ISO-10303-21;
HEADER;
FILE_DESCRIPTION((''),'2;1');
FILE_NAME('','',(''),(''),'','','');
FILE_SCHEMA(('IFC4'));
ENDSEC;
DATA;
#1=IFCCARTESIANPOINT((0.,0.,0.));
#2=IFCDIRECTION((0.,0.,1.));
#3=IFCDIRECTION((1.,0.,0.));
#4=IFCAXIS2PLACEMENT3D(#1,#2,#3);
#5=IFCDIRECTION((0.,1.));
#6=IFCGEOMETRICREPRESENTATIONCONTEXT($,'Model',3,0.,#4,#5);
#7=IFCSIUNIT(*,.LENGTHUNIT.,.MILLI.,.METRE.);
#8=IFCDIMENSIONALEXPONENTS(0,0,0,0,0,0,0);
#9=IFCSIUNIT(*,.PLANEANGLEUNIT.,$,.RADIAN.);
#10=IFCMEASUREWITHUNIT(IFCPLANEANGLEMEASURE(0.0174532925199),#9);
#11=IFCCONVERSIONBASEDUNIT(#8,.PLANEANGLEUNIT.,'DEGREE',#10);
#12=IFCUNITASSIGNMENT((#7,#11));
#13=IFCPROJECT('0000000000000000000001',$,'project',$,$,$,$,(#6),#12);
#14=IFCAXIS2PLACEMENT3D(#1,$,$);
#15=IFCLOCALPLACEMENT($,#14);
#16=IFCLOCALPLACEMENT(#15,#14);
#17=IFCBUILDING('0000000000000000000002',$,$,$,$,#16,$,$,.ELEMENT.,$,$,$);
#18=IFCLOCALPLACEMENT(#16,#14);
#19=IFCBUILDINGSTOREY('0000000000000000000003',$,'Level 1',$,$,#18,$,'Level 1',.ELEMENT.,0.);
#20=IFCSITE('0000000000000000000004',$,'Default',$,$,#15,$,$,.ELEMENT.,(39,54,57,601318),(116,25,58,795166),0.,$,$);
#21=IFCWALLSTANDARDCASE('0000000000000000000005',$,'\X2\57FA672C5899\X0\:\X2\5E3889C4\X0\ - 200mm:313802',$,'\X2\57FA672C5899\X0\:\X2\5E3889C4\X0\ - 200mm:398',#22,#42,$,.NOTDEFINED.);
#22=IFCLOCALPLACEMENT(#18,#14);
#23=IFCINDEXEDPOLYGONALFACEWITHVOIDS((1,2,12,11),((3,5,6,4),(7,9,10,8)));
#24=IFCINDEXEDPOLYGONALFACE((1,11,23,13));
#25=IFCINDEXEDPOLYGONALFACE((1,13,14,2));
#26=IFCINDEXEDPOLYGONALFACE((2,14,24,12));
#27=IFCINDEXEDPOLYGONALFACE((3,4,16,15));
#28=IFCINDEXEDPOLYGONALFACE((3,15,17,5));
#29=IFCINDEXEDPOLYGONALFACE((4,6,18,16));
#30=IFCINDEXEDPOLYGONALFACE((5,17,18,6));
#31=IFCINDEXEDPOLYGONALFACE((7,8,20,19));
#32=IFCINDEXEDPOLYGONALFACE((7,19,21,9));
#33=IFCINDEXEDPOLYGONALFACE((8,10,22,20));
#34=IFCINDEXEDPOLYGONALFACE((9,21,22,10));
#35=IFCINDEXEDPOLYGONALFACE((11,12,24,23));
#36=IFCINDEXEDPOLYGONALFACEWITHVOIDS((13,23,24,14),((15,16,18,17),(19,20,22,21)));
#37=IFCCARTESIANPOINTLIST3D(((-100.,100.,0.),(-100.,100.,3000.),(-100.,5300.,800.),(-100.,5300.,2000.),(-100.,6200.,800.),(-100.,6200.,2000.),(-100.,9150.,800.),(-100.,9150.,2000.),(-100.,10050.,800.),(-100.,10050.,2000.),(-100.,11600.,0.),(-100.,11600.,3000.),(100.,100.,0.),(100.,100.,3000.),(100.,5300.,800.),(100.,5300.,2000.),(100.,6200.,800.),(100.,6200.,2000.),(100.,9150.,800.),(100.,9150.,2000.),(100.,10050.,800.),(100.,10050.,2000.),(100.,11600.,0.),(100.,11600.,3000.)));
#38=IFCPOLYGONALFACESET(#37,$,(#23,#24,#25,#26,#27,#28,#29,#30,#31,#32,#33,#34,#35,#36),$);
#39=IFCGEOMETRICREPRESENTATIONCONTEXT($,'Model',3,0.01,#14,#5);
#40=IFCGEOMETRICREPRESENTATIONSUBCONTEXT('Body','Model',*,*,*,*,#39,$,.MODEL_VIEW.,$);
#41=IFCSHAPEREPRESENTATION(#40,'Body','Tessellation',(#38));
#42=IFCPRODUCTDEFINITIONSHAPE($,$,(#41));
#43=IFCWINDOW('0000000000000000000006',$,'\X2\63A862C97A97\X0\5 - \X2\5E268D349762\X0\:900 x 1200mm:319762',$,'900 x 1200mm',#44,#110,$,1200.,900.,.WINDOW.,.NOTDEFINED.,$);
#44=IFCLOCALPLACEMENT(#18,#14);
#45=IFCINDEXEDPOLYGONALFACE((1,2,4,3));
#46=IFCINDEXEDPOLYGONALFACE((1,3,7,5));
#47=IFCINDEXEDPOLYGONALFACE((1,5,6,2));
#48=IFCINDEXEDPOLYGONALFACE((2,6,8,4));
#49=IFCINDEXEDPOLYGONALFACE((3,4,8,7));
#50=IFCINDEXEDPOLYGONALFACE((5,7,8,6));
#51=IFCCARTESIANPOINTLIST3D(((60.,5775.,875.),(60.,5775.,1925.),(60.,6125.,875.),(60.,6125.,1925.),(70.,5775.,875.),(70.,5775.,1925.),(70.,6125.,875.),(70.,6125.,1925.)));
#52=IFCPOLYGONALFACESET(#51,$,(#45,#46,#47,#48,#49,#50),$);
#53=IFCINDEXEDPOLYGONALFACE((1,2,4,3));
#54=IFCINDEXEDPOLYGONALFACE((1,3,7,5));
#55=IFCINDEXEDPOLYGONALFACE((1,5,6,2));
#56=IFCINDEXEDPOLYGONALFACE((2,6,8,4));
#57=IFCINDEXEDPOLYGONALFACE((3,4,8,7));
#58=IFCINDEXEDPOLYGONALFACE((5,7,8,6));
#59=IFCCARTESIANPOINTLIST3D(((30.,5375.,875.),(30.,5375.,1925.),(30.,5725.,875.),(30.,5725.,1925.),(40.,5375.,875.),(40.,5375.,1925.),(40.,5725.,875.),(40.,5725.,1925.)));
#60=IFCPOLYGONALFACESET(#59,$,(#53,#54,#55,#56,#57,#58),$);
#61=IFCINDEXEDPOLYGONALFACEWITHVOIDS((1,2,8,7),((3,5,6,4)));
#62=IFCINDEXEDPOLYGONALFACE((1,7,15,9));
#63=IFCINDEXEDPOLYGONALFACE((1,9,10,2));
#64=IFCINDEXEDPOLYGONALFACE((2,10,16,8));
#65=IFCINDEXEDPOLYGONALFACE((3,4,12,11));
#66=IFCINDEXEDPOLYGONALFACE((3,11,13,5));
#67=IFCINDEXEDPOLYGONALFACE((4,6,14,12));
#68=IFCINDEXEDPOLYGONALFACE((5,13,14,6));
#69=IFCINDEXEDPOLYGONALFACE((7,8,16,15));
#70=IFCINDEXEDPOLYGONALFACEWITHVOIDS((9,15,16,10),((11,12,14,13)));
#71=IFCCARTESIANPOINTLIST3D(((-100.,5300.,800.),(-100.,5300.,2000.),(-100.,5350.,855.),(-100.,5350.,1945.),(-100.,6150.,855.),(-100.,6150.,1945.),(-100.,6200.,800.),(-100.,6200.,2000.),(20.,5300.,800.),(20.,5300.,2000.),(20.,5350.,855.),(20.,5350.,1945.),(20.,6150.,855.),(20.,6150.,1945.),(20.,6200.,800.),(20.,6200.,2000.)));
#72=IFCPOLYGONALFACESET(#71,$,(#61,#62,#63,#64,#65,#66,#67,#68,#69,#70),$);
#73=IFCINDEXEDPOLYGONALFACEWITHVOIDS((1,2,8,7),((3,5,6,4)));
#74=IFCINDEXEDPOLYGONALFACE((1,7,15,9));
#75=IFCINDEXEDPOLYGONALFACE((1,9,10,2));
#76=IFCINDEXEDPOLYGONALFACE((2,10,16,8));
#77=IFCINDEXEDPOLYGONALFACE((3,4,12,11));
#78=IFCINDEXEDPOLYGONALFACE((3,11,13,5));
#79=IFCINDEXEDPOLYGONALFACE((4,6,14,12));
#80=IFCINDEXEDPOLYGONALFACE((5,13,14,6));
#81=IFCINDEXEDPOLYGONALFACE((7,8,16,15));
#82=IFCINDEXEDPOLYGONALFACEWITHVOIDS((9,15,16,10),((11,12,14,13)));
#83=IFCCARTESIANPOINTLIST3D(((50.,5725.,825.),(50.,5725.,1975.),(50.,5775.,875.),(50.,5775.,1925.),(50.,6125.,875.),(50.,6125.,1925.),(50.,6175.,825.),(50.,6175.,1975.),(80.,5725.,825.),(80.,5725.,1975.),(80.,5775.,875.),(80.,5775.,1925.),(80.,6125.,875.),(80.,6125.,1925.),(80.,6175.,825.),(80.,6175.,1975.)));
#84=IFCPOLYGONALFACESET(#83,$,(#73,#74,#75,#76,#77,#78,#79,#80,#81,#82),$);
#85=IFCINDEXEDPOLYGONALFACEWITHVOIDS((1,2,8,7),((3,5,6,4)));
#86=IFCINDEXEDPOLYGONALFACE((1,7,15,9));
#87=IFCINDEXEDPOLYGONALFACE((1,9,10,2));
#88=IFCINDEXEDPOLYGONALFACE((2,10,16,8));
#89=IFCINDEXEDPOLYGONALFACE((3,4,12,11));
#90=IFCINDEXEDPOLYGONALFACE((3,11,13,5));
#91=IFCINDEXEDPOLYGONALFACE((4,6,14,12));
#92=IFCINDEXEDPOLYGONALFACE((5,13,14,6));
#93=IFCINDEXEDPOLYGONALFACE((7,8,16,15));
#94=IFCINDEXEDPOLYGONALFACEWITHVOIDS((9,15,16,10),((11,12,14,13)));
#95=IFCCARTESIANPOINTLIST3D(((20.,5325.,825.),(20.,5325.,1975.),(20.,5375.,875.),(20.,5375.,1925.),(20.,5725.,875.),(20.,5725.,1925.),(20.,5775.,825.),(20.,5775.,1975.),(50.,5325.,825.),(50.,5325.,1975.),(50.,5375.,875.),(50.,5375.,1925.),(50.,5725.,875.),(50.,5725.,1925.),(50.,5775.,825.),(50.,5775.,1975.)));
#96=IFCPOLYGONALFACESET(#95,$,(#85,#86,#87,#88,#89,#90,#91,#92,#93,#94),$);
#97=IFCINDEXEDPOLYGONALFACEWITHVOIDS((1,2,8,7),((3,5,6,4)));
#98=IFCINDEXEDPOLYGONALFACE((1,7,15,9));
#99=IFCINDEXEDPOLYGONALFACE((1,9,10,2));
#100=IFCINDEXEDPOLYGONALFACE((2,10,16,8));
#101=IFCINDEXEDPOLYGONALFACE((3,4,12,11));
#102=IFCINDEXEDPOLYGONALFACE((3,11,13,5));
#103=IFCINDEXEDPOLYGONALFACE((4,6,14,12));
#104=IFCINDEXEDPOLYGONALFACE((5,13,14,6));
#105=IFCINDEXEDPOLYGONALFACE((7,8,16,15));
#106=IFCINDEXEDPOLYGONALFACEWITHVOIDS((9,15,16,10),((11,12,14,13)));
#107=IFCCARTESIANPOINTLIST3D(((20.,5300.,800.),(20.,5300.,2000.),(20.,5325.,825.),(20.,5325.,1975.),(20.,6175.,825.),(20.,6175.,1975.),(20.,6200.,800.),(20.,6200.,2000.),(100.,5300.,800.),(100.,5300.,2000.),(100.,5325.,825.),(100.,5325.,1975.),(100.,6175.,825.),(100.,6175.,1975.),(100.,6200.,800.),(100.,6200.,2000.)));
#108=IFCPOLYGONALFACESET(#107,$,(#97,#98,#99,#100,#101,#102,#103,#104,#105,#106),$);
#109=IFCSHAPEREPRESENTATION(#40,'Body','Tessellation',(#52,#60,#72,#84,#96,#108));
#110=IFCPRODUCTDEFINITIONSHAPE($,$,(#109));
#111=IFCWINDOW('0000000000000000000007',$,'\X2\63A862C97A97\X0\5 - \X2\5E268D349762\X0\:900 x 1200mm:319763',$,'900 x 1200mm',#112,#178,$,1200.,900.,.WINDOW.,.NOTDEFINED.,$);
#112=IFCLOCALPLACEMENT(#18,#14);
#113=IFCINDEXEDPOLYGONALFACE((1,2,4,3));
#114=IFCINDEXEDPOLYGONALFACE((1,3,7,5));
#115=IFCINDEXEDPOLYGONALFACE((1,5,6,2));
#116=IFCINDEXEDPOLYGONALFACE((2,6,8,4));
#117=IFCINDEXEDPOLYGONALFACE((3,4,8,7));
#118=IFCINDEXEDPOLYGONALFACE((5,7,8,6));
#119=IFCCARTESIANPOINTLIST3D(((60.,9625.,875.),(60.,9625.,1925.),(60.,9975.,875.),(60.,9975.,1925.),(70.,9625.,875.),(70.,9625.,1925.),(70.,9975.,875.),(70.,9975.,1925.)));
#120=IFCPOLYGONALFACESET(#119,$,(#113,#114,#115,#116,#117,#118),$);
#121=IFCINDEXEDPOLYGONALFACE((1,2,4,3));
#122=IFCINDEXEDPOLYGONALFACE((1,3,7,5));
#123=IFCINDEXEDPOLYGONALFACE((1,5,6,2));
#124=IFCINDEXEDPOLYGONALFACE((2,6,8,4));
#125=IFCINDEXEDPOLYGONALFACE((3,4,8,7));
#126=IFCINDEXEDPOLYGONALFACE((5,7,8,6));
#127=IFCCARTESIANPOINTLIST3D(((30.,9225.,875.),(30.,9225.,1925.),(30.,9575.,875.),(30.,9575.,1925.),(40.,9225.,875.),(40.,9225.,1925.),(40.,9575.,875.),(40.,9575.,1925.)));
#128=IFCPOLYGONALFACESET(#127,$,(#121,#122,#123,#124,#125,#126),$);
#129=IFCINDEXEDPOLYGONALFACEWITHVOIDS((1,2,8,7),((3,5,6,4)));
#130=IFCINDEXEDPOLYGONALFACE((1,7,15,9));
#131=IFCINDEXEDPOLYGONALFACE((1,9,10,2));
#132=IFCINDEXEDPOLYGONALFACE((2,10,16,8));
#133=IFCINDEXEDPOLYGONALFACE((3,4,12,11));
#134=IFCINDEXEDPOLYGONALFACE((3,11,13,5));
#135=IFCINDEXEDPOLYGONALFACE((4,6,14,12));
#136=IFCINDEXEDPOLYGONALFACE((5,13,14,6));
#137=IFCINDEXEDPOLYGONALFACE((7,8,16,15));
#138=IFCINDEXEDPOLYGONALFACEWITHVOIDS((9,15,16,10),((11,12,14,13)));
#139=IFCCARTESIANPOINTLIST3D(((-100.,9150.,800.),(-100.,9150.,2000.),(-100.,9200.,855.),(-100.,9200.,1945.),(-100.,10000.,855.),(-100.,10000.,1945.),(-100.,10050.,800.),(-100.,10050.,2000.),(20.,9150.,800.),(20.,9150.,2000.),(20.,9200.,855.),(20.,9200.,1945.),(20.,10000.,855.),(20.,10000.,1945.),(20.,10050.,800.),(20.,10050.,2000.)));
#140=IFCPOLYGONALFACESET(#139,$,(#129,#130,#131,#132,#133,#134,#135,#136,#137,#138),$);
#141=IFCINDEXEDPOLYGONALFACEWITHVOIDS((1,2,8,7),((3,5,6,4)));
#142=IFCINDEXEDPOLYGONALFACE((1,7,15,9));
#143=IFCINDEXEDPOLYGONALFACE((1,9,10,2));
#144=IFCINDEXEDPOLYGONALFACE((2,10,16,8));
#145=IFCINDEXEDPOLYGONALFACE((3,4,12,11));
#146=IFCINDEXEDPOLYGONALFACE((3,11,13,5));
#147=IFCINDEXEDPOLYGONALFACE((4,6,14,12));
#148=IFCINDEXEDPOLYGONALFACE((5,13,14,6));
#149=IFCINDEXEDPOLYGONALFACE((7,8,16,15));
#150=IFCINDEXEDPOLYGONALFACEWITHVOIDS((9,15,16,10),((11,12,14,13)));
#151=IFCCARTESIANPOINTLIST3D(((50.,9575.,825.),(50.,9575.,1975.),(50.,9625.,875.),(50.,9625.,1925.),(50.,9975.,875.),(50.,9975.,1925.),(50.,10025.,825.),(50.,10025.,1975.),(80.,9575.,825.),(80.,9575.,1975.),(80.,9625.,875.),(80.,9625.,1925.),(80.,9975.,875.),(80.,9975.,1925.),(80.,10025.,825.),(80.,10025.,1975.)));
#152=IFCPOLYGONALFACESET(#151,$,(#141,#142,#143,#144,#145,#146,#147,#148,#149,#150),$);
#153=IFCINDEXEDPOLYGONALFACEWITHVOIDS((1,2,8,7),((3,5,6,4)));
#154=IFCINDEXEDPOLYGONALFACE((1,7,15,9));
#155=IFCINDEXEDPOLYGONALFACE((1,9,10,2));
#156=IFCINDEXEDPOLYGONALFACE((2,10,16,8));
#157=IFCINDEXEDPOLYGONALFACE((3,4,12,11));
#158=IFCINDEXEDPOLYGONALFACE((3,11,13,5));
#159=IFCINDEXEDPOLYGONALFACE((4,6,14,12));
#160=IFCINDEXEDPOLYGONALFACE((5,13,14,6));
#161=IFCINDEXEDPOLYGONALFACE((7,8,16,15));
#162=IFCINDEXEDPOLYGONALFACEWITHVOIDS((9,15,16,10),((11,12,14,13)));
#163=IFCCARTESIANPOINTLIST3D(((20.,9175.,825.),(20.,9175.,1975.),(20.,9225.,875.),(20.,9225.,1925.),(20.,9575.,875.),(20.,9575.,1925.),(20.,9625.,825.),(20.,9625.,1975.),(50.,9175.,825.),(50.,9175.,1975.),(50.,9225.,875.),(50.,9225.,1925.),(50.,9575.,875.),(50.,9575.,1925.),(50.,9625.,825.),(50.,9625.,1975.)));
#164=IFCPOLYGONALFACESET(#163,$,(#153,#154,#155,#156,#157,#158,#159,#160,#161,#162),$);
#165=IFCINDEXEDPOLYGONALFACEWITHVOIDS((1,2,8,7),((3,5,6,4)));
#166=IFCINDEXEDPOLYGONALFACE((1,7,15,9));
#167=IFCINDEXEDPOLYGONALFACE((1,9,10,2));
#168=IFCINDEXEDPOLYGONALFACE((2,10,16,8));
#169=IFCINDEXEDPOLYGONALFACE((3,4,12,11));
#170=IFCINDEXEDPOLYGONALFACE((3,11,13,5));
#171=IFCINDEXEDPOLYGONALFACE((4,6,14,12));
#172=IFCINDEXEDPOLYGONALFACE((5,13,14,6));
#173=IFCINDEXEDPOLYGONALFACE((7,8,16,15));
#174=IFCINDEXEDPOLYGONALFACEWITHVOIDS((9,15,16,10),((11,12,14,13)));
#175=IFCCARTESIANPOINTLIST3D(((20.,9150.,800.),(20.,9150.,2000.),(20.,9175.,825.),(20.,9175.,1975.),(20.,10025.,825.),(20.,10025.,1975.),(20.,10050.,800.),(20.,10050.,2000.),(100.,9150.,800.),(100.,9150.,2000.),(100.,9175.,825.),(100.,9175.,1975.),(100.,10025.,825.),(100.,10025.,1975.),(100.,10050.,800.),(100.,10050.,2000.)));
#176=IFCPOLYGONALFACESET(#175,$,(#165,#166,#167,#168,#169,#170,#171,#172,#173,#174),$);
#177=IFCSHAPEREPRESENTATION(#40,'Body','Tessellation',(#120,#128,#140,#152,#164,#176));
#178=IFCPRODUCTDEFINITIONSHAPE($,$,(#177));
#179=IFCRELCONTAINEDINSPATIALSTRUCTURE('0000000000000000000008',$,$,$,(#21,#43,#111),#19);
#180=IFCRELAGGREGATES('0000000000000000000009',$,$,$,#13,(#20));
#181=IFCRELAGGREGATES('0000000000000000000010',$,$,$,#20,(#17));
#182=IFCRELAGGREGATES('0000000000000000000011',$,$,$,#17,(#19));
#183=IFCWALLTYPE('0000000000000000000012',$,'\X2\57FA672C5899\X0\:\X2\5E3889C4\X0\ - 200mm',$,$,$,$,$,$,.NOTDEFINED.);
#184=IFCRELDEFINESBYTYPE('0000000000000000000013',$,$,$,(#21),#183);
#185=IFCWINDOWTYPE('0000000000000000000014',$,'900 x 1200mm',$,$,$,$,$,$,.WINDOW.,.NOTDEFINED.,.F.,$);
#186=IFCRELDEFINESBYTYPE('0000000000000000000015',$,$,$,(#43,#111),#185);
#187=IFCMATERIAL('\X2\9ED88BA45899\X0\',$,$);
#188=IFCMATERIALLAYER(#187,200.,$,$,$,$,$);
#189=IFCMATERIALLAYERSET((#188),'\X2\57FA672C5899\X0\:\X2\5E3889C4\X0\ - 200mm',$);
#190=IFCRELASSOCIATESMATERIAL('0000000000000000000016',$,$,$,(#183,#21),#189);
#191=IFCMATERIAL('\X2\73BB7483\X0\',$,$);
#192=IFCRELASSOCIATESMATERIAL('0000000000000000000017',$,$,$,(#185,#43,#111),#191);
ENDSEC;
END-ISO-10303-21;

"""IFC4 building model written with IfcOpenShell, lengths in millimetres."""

from ifc_helpers import new_model, entity, si_unit, converted_unit, direction, frame, frame_2d, origin, origin_with_axes, origin_2d_with_axis, place, context, subcontext, project, spatial, polyline, rectangle, outline, extrude, source, transform, mapped, material, layer, layer_set, layer_usage, type_object, type_shapes, element, fill, save


model = new_model("IFC4")

# Units and contexts
model_context_1 = context("Model", 3, precision=0.0, world=origin_with_axes(), true_north=direction((0.0, 1.0)))
model_context_2 = context("Model", 3, precision=0.01, world=origin(), true_north=direction((0.0, 1.0)))
body_context = subcontext(model_context_2, "Body", "Model", "MODEL_VIEW")
ifc_project = project(units=[si_unit("LENGTHUNIT", "METRE", prefix="MILLI"), converted_unit("PLANEANGLEUNIT", "DEGREE", entity("IfcPlaneAngleMeasure", 0.0174532925199), si_unit("PLANEANGLEUNIT", "RADIAN"), dimensions=[0, 0, 0, 0, 0, 0, 0])], contexts=[model_context_1])

# Site, building, storey
site_placement = place(None, origin())
site = spatial("IfcSite", under=ifc_project, at=site_placement, Name="Default", CompositionType="ELEMENT", RefLatitude=(39, 54, 57, 601318), RefLongitude=(116, 25, 58, 795166), RefElevation=0.0)
building_placement = place(site_placement, origin())
building = spatial("IfcBuilding", under=site, at=building_placement, CompositionType="ELEMENT")
storey_placement = place(building_placement, origin())
storey = spatial("IfcBuildingStorey", under=building, at=storey_placement, Name="Level 1", LongName="Level 1", CompositionType="ELEMENT", Elevation=0.0)

# Shared definitions
ifc_material_1 = material(Name="默认墙")
ifc_layer = layer(ifc_material_1, 200.0)
ifc_layer_set = layer_set([ifc_layer], Name="基本墙:常规 - 200mm")
wall_type = type_object("IfcWallType", Name="基本墙:常规 - 200mm", PredefinedType="NOTDEFINED", material=ifc_layer_set)
ifc_material_2 = material(Name="玻璃")

# Wall, openings, windows
ifc_layer_usage_1 = layer_usage(ifc_layer_set, "AXIS2", "NEGATIVE", 100.0)
wall_1_placement = place(storey_placement, frame((0.0, 100.0, 0.0), z_axis=(0.0, 0.0, 1.0), x_axis=(0.0, 1.0, 0.0)))
wall_1 = element("IfcWallStandardCase", 1, at=wall_1_placement, inside=storey, type_object=wall_type, material=ifc_layer_usage_1, Name="基本墙:常规 - 200mm:313802", ObjectType="基本墙:常规 - 200mm:398", PredefinedType="NOTDEFINED", context=body_context, shape_type="SweptSolid", body=[
    extrude(rectangle(XDim=11500.0, YDim=200.0, at=frame_2d((5750.0, 0.0), x_axis=(-1.0, 0.0))), origin(), (0.0, 0.0, 1.0), 3000.0),
])
opening_1_placement = place(wall_1_placement, frame((6100.0, 100.0, 800.0)))
opening_1 = element("IfcOpeningElement", 2, at=opening_1_placement, cuts=wall_1, ObjectType="Opening", PredefinedType="OPENING", context=body_context, shape_type="SweptSolid", body=[
    extrude(rectangle(XDim=1200.0, YDim=900.0, at=frame_2d((600.0, 450.0), x_axis=(-1.0, 0.0))), frame((0.0, 0.0, 0.0), z_axis=(0.0, -1.0, 0.0), x_axis=(0.0, 0.0, 1.0)), (0.0, 0.0, 1.0), 200.0),
])
opening_2_placement = place(wall_1_placement, frame((9950.0, 100.0, 800.0)))
opening_2 = element("IfcOpeningElement", 3, at=opening_2_placement, cuts=wall_1, ObjectType="Opening", PredefinedType="OPENING", context=body_context, shape_type="SweptSolid", body=[
    extrude(rectangle(XDim=1200.0, YDim=900.0, at=frame_2d((600.0, 450.0), x_axis=(-1.0, 0.0))), frame((0.0, 0.0, 0.0), z_axis=(0.0, -1.0, 0.0), x_axis=(0.0, 0.0, 1.0)), (0.0, 0.0, 1.0), 200.0),
])
window_type_1 = type_object("IfcWindowType", Name="900 x 1200mm", ParameterTakesPrecedence=False, PartitioningType="NOTDEFINED", PredefinedType="WINDOW", material=ifc_material_2)
shared_shape_1 = source(origin(), body_context, "Body", "SweptSolid", [
    extrude(rectangle(XDim=10.0, YDim=350.0, at=origin_2d_with_axis()), frame((250.0, 165.0, 75.0), z_axis=(0.0, 0.0, 1.0), x_axis=(0.0, -1.0, 0.0)), (0.0, 0.0, 1.0), 1050.0),
    extrude(rectangle(XDim=10.0, YDim=350.0, at=origin_2d_with_axis()), frame((650.0, 135.0, 75.0), z_axis=(0.0, 0.0, 1.0), x_axis=(0.0, -1.0, 0.0)), (0.0, 0.0, 1.0), 1050.0),
    extrude(outline(polyline([(-450.0, -600.0), (450.0, -600.0), (450.0, 600.0), (-450.0, 600.0), (-450.0, -600.0)]), holes=[polyline([(400.0, -545.0), (-400.0, -545.0), (-400.0, 545.0), (400.0, 545.0), (400.0, -545.0)])]), frame((450.0, 0.0, 600.0), z_axis=(0.0, 1.0, 0.0), x_axis=(1.0, 0.0, 0.0)), (0.0, 0.0, 1.0), 120.0),
    extrude(outline(polyline([(-225.0, -575.0), (225.0, -575.0), (225.0, 575.0), (-225.0, 575.0), (-225.0, -575.0)]), holes=[polyline([(-175.0, -525.0), (-175.0, 525.0), (175.0, 525.0), (175.0, -525.0), (-175.0, -525.0)])]), frame((250.0, 150.0, 600.0), z_axis=(0.0, 1.0, 0.0), x_axis=(-1.0, 0.0, 0.0)), (0.0, 0.0, 1.0), 30.0),
    extrude(outline(polyline([(-225.0, -575.0), (225.0, -575.0), (225.0, 575.0), (-225.0, 575.0), (-225.0, -575.0)]), holes=[polyline([(-175.0, -525.0), (-175.0, 525.0), (175.0, 525.0), (175.0, -525.0), (-175.0, -525.0)])]), frame((650.0, 120.0, 600.0), z_axis=(0.0, 1.0, 0.0), x_axis=(1.0, 0.0, 0.0)), (0.0, 0.0, 1.0), 30.0),
    extrude(outline(polyline([(-450.0, -600.0), (450.0, -600.0), (450.0, 600.0), (-450.0, 600.0), (-450.0, -600.0)]), holes=[polyline([(-425.0, 575.0), (425.0, 575.0), (425.0, -575.0), (-425.0, -575.0), (-425.0, 575.0)])]), frame((450.0, 120.0, 600.0), z_axis=(0.0, 1.0, 0.0), x_axis=(1.0, 0.0, 0.0)), (0.0, 0.0, 1.0), 80.0),
])
type_shapes(window_type_1, [shared_shape_1])
window_1_placement = place(opening_1_placement, frame((0.0, 0.0, 0.0), z_axis=(0.0, 0.0, 1.0), x_axis=(-1.0, 0.0, 0.0)))
window_1 = element("IfcWindow", 4, at=window_1_placement, inside=storey, type_object=window_type_1, material=ifc_material_2, Name="推拉窗5 - 带贴面:900 x 1200mm:319762", ObjectType="900 x 1200mm", OverallHeight=1200.0, OverallWidth=900.0, PartitioningType="NOTDEFINED", PredefinedType="WINDOW", context=body_context, shape_type="MappedRepresentation", body=[
    mapped(shared_shape_1, transform((0.0, 0.0, 0.0), scale=1.0)),
])
fill(opening_1, window_1)
window_2_placement = place(opening_2_placement, frame((0.0, 0.0, 0.0), z_axis=(0.0, 0.0, 1.0), x_axis=(-1.0, 0.0, 0.0)))
window_2 = element("IfcWindow", 5, at=window_2_placement, inside=storey, type_object=window_type_1, material=ifc_material_2, Name="推拉窗5 - 带贴面:900 x 1200mm:319763", ObjectType="900 x 1200mm", OverallHeight=1200.0, OverallWidth=900.0, PartitioningType="NOTDEFINED", PredefinedType="WINDOW", context=body_context, shape_type="MappedRepresentation", body=[
    mapped(shared_shape_1, transform((0.0, 0.0, 0.0), scale=1.0)),
])
fill(opening_2, window_2)

save(model, "model.ifc")
